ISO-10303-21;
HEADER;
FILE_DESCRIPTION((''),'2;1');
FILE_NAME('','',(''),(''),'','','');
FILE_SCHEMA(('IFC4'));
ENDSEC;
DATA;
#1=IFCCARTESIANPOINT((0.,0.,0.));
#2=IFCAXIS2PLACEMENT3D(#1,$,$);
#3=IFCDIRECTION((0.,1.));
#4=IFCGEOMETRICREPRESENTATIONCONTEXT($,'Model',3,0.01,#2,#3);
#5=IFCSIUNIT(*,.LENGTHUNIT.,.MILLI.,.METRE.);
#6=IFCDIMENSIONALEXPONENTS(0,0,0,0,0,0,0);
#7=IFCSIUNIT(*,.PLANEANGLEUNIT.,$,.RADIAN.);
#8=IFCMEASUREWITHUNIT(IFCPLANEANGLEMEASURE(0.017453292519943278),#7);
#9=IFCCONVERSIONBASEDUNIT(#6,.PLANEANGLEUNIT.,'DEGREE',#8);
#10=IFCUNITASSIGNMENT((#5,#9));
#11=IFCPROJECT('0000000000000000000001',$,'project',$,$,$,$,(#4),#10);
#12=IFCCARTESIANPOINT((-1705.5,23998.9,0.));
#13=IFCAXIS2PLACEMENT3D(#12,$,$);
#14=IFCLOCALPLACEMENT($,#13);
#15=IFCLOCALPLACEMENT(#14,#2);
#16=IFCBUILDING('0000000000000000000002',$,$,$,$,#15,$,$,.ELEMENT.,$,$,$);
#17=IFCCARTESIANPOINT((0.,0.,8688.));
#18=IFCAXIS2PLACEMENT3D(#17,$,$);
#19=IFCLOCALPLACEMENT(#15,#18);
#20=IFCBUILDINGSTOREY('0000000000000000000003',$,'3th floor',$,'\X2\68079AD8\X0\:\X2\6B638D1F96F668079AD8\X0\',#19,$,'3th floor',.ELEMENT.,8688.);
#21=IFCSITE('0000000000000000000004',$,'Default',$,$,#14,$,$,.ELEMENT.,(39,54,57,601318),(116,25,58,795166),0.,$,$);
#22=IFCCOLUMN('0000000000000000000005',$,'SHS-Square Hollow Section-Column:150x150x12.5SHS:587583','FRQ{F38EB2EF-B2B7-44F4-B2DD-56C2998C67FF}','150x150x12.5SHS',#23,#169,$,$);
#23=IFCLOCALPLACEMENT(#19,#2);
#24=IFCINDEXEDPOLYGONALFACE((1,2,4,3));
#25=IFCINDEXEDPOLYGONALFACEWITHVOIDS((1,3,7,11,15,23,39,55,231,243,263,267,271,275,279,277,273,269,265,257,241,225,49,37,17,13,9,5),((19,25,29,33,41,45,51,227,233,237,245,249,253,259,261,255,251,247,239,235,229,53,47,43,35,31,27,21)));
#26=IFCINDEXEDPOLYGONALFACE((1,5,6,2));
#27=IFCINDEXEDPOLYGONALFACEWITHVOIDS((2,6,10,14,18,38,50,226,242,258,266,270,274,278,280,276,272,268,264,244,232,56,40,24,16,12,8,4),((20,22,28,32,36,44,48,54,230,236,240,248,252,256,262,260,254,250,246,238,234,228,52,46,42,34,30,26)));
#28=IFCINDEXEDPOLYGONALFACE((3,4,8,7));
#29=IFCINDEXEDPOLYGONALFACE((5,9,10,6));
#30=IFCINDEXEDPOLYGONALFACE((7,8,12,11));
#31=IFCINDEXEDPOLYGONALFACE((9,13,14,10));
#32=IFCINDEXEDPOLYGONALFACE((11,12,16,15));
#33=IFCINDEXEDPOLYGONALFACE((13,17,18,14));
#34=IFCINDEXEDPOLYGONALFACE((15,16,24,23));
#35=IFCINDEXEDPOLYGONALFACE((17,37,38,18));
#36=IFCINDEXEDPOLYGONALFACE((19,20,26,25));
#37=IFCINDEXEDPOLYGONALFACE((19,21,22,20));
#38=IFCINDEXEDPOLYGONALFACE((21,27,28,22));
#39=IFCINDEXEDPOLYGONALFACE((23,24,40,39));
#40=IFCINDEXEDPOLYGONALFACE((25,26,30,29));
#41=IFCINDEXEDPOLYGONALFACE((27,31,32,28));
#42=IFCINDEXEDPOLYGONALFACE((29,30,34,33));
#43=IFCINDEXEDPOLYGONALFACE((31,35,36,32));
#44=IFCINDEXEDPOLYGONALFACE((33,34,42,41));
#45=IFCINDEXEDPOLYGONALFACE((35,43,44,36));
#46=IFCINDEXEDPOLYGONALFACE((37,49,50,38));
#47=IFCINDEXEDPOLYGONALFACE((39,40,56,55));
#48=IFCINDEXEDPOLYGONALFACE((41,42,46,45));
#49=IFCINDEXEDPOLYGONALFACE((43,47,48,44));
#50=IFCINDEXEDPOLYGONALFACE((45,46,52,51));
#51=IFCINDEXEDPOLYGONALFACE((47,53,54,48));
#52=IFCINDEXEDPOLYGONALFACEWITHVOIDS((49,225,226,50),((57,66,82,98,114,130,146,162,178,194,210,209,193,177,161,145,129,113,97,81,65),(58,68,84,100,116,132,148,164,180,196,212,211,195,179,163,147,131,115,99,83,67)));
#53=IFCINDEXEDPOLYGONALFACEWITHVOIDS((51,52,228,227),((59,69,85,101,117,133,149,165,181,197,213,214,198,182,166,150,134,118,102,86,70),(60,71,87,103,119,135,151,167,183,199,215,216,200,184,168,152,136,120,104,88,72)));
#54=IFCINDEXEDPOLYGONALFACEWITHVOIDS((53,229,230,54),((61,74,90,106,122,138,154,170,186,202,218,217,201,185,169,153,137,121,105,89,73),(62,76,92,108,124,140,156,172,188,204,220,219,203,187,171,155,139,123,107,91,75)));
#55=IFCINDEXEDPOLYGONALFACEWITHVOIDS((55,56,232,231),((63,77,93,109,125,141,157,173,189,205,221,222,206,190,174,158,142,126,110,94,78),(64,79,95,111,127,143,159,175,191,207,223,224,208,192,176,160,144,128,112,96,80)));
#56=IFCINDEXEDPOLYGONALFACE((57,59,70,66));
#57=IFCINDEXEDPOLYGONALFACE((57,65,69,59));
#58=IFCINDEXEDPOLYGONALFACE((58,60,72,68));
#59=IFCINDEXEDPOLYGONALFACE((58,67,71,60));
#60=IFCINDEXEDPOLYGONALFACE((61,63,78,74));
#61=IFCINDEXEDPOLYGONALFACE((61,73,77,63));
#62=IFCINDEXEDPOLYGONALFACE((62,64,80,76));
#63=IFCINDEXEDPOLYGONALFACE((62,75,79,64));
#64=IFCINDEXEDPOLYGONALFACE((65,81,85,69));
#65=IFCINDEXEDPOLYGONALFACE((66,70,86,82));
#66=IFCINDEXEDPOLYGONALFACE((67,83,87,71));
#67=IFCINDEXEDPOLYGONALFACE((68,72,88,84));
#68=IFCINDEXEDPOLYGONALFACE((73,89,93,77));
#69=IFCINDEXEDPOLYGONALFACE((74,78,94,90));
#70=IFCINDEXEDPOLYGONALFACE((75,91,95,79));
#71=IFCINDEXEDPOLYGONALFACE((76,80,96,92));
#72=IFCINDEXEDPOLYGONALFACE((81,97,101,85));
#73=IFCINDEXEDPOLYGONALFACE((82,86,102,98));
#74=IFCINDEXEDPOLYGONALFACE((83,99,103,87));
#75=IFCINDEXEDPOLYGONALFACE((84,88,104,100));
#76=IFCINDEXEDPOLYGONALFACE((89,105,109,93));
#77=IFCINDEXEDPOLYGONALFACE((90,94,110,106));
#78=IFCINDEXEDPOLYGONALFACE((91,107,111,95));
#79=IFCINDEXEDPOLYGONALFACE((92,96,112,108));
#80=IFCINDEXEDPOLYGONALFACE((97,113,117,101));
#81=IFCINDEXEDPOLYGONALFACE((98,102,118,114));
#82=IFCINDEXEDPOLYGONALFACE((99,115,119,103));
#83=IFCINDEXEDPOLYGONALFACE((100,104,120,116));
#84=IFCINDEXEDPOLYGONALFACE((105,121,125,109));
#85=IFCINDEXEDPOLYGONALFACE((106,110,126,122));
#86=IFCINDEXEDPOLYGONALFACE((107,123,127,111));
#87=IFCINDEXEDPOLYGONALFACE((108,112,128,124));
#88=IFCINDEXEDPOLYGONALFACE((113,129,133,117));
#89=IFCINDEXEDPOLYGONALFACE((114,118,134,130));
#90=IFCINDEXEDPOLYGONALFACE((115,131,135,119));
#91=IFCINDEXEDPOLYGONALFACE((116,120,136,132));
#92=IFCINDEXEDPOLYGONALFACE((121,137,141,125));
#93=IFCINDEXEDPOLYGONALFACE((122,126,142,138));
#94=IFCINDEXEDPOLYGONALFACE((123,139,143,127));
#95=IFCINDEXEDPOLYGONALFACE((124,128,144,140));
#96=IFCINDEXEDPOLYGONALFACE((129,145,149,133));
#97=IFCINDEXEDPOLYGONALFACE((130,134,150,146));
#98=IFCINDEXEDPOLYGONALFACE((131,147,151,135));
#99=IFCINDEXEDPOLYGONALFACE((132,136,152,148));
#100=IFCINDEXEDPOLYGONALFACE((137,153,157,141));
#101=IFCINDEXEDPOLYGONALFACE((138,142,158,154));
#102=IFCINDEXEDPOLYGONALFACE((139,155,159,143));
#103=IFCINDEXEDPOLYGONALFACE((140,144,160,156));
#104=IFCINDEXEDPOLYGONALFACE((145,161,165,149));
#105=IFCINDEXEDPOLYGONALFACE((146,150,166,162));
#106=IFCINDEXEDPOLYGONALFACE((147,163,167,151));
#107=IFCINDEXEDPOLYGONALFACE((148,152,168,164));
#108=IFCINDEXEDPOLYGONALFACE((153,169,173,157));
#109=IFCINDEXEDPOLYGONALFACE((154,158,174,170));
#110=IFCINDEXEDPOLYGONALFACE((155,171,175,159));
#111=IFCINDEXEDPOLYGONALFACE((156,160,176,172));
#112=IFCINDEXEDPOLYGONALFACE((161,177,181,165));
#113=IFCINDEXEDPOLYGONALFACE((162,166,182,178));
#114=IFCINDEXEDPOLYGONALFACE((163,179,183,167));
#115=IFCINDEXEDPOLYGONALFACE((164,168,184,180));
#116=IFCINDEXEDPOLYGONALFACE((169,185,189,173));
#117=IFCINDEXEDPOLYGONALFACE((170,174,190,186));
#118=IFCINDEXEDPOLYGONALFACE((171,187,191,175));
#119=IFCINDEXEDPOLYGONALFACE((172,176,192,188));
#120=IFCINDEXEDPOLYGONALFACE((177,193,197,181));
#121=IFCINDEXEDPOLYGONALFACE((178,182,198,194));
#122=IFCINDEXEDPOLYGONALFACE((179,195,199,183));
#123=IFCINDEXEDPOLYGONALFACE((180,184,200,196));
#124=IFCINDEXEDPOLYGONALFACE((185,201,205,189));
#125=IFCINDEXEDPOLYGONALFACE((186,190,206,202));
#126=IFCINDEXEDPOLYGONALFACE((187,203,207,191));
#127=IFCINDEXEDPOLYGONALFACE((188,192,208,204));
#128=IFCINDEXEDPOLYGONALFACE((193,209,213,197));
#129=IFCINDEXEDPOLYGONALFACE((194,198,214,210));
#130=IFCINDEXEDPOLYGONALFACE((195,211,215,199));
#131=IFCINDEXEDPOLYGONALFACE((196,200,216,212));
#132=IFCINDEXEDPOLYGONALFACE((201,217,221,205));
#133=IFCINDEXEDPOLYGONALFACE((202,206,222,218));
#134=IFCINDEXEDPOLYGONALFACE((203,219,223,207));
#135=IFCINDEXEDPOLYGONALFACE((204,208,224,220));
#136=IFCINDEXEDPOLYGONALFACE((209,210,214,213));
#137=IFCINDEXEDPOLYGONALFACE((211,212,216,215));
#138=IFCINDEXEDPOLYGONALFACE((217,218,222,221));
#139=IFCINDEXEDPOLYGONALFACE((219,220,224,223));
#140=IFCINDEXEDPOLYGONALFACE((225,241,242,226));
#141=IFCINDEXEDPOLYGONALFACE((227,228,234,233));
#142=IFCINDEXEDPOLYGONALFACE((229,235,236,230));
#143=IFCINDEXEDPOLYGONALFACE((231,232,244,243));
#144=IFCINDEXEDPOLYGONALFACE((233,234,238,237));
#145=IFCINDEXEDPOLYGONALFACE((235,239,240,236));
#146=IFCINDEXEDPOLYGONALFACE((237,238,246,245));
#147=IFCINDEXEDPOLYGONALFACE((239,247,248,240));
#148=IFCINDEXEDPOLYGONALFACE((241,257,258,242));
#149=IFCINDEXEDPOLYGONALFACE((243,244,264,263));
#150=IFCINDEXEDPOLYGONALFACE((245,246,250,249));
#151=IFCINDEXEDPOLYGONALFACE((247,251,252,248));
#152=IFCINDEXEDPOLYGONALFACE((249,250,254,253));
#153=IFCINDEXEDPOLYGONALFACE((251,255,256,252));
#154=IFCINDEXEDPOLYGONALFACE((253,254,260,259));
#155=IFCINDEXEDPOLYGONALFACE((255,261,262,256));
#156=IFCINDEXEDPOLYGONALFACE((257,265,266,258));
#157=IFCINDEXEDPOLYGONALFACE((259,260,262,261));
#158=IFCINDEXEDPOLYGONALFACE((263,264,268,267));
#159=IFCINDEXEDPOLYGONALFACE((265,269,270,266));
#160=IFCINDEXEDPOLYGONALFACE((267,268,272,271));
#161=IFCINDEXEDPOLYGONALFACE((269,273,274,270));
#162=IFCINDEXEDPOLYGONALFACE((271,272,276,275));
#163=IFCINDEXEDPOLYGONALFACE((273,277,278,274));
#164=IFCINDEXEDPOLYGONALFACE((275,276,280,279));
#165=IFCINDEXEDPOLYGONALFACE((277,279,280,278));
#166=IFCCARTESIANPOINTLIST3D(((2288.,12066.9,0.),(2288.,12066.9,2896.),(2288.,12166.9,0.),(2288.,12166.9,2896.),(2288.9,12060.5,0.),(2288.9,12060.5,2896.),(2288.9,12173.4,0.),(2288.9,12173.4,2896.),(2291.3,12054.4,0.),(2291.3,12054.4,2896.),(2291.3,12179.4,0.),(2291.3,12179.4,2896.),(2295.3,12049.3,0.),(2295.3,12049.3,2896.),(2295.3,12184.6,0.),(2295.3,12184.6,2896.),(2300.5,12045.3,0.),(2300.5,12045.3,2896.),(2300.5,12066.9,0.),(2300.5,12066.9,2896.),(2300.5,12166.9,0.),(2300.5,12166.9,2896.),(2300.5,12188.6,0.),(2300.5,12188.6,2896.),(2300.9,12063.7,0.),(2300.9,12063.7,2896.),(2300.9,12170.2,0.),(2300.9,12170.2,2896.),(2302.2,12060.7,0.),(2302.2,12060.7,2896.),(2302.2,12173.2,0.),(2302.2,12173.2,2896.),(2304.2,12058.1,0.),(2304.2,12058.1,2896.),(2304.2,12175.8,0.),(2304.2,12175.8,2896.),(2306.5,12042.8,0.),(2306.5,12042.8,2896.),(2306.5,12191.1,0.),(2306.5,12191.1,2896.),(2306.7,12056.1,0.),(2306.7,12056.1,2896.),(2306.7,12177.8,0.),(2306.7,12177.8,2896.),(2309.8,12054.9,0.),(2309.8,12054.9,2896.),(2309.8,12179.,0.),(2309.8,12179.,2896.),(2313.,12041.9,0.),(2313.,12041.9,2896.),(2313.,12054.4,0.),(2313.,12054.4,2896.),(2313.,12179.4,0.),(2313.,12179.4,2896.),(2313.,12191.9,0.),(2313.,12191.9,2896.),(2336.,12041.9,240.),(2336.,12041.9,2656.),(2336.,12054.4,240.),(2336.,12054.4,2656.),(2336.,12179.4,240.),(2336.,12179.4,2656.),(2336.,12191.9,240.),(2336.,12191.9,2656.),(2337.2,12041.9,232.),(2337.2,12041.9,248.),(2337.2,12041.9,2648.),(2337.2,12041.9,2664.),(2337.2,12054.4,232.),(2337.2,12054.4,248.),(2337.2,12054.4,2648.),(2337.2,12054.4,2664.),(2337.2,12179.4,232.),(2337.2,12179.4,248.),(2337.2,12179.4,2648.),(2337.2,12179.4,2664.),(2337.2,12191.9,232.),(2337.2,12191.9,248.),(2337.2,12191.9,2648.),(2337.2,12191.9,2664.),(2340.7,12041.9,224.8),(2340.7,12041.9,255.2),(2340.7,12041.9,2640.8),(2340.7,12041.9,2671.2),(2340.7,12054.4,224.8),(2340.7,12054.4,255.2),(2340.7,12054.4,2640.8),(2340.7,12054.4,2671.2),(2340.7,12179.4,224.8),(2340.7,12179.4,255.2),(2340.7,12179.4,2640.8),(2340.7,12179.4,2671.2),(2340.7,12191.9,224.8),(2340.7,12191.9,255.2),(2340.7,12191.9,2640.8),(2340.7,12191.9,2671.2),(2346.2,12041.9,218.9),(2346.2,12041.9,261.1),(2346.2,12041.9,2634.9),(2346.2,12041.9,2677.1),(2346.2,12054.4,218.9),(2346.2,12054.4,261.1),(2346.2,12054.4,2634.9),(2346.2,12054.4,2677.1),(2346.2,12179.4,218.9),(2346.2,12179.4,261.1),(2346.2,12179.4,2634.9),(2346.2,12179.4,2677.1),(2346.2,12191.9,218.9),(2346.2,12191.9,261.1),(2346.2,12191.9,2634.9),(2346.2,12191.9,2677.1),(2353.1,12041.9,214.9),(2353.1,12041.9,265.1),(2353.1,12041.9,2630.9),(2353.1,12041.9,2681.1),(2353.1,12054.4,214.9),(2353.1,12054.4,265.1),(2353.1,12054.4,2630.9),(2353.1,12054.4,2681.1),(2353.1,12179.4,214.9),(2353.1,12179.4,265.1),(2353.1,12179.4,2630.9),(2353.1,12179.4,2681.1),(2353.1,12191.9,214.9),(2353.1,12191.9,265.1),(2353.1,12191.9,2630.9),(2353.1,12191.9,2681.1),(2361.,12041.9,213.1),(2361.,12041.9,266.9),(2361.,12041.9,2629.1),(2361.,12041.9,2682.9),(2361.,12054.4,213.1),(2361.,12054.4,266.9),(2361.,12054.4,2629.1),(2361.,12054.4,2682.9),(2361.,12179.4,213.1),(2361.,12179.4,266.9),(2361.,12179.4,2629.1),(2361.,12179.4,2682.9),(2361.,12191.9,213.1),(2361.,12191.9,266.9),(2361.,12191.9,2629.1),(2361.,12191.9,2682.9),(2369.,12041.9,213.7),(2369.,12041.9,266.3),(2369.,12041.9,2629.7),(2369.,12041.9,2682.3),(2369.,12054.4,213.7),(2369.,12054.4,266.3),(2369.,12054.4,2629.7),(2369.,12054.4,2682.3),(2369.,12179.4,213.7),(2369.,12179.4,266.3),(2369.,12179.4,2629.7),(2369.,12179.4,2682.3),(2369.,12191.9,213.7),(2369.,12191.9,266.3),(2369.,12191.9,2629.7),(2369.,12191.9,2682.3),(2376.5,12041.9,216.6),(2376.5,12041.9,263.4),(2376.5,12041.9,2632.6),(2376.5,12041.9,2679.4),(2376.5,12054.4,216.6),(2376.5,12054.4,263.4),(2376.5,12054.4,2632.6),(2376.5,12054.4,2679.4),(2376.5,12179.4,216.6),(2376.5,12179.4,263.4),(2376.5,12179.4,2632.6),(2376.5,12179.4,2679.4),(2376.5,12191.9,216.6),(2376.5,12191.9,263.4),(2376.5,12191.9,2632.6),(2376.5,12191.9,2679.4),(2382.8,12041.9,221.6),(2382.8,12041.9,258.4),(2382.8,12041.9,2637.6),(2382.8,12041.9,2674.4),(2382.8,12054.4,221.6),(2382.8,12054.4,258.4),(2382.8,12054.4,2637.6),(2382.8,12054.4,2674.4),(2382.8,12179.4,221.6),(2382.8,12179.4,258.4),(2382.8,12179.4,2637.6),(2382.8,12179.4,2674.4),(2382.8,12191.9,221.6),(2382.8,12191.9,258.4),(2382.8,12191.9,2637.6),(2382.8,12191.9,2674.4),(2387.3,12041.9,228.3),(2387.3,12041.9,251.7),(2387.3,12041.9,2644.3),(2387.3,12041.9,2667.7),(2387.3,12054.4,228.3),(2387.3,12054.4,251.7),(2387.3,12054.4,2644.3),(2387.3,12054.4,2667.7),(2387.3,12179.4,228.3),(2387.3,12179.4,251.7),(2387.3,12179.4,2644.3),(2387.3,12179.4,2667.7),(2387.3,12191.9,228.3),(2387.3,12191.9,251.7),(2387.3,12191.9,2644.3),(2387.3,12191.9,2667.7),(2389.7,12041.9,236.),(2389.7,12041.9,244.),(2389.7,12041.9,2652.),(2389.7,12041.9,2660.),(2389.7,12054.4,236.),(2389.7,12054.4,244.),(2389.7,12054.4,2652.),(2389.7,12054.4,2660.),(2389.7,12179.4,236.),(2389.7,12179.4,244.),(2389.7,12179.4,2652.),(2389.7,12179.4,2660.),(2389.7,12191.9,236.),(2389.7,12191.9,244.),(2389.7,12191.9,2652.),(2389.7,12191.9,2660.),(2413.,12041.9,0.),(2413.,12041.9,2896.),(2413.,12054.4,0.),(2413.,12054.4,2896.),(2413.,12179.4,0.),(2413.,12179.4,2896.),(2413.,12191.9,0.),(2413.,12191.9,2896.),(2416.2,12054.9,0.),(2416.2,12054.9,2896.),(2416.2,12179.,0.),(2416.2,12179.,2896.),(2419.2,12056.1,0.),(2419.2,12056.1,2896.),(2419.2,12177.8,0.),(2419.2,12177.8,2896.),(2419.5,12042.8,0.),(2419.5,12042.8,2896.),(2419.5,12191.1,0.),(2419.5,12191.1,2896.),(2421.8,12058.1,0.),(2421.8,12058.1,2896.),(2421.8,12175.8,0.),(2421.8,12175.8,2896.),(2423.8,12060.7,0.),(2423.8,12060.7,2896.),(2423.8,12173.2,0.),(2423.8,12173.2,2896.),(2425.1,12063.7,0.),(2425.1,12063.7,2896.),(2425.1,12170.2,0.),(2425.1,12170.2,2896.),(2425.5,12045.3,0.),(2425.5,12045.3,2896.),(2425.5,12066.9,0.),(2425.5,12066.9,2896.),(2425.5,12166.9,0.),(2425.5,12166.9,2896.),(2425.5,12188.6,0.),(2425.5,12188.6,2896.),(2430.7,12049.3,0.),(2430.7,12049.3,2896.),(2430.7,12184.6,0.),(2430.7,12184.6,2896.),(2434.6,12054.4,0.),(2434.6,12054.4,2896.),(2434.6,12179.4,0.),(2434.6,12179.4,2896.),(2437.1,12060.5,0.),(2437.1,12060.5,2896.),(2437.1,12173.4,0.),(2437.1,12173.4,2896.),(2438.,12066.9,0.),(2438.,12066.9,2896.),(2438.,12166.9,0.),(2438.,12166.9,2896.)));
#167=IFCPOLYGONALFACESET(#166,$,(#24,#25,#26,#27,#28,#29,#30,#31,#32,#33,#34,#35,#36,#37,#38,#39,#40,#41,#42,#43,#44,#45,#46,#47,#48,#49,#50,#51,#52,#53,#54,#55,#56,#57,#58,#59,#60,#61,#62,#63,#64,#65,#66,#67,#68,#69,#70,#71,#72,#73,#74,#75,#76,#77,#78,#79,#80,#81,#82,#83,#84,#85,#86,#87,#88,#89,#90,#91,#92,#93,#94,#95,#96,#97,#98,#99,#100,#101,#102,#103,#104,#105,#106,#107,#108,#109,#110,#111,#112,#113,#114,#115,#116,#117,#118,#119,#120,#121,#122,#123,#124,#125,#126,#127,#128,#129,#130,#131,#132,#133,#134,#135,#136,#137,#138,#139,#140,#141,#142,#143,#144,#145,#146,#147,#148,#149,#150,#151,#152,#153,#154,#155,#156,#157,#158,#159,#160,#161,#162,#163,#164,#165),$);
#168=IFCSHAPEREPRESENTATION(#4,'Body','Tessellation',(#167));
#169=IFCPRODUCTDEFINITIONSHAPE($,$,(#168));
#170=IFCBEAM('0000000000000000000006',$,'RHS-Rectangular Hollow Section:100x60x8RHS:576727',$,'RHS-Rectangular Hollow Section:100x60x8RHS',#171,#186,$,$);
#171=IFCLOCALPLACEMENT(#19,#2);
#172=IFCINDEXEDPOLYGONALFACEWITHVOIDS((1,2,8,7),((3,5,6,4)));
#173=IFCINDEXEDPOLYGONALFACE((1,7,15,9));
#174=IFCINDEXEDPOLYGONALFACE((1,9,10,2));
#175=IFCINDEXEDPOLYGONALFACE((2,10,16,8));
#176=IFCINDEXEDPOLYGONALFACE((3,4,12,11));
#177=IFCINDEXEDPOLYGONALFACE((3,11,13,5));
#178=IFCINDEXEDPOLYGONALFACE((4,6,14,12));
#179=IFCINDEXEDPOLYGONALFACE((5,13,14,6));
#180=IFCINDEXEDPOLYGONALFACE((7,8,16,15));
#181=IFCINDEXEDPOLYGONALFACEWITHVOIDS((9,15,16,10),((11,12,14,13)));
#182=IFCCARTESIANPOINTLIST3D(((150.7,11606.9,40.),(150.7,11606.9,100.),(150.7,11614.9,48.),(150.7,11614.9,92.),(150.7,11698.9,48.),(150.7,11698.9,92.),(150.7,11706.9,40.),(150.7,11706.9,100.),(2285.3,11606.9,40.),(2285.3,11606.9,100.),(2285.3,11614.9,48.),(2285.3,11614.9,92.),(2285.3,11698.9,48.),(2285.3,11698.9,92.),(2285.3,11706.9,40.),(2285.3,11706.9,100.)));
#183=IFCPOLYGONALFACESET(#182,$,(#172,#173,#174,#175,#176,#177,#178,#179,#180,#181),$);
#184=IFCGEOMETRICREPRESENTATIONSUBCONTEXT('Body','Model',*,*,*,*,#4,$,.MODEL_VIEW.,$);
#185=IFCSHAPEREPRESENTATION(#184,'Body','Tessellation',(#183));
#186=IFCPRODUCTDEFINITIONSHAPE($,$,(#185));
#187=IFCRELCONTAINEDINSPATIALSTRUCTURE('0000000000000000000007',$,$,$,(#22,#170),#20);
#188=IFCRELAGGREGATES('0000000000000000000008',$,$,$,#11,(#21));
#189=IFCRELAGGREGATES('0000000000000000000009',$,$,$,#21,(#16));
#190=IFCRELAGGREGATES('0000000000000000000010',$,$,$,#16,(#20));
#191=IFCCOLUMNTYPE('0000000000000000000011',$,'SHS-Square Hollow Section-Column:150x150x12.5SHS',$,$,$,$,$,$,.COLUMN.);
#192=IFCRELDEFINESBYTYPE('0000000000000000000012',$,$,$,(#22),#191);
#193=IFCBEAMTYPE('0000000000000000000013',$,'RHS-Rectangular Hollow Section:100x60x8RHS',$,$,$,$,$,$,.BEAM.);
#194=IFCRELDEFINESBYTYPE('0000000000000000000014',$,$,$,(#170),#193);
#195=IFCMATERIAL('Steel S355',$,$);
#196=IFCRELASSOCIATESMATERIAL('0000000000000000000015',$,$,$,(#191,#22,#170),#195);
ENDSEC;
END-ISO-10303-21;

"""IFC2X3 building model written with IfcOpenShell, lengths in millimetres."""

from ifc_helpers import new_model, entity, si_unit, converted_unit, direction, frame, frame_2d, origin, origin_2d, place, context, subcontext, project, spatial, circle_curve, rectangle, hollow_rectangle, outline, extrude, boolean, material, type_object, element, save


model = new_model("IFC2X3")

# Units and contexts
model_context = context("Model", 3, precision=0.01, world=origin(), true_north=direction((0.0, 1.0)))
body_context = subcontext(model_context, "Body", "Model", "MODEL_VIEW")
ifc_project = project(units=[si_unit("LENGTHUNIT", "METRE", prefix="MILLI"), converted_unit("PLANEANGLEUNIT", "DEGREE", entity("IfcPlaneAngleMeasure", 0.017453292519943278), si_unit("PLANEANGLEUNIT", "RADIAN"), dimensions=[0, 0, 0, 0, 0, 0, 0])], contexts=[model_context])

# Site, building, storey
site_placement = place(None, frame((-1705.5, 23998.9, 0.0)))
site = spatial("IfcSite", under=ifc_project, at=site_placement, Name="Default", CompositionType="ELEMENT", RefLatitude=(39, 54, 57, 601318), RefLongitude=(116, 25, 58, 795166), RefElevation=0.0)
building_placement = place(site_placement, origin())
building = spatial("IfcBuilding", under=site, at=building_placement, CompositionType="ELEMENT")
storey_placement = place(building_placement, frame((0.0, 0.0, 8688.0)))
storey = spatial("IfcBuildingStorey", under=building, at=storey_placement, Name="3th floor", ObjectType="标高:正负零标高", LongName="3th floor", CompositionType="ELEMENT", Elevation=8688.0)

# Shared definitions
ifc_material_1 = material(Name="Steel S355")

# Column, openings
column_type_1 = type_object("IfcColumnType", Name="SHS-Square Hollow Section-Column:150x150x12.5SHS", PredefinedType="COLUMN", material=ifc_material_1)
column_1_placement = place(storey_placement, frame((2363.0, 12116.9, 2896.0), z_axis=(0.0, 0.0, 1.0), x_axis=(0.0, -1.0, 0.0)))
column_1 = element("IfcColumn", 1, at=column_1_placement, inside=storey, type_object=column_type_1, material=ifc_material_1, Name="SHS-Square Hollow Section-Column:150x150x12.5SHS:587583", Description="FRQ{F38EB2EF-B2B7-44F4-B2DD-56C2998C67FF}", ObjectType="150x150x12.5SHS", context=model_context, shape_type="SweptSolid", body=[
    extrude(hollow_rectangle(XDim=150.0, YDim=150.0, WallThickness=12.5, InnerFilletRadius=12.5, OuterFilletRadius=25.0, at=origin_2d()), origin(), (0.0, 0.0, -1.0), 2896.0),
])
opening_1_placement = place(column_1_placement, frame((175.1, 0.0, -2896.0), z_axis=(-1.0, 0.0, 0.0), x_axis=(0.0, -1.0, 0.0)))
element("IfcOpeningElement", 2, at=opening_1_placement, cuts=column_1, ObjectType="Opening", context=model_context, shape_type="SweptSolid", body=[
    extrude(outline(circle_curve(frame_2d((0.0, 240.0), x_axis=(1.0, 0.0)), 27.0)), origin(), (0.0, 0.0, 1.0), 350.2),
])
opening_2_placement = place(column_1_placement, frame((175.1, 0.0, 0.0), z_axis=(-1.0, 0.0, 0.0), x_axis=(0.0, -1.0, 0.0)))
element("IfcOpeningElement", 3, at=opening_2_placement, cuts=column_1, ObjectType="Opening", context=model_context, shape_type="SweptSolid", body=[
    extrude(outline(circle_curve(frame_2d((0.0, -240.0), x_axis=(1.0, 0.0)), 27.0)), origin(), (0.0, 0.0, 1.0), 350.2),
])

# Beam
beam_type_1 = type_object("IfcBeamType", Name="RHS-Rectangular Hollow Section:100x60x8RHS", PredefinedType="BEAM")
beam_1_placement = place(storey_placement, frame((150.7, 11706.9, 70.0)))
element("IfcBeam", 4, at=beam_1_placement, inside=storey, type_object=beam_type_1, material=ifc_material_1, Name="RHS-Rectangular Hollow Section:100x60x8RHS:576727", ObjectType="RHS-Rectangular Hollow Section:100x60x8RHS", context=body_context, shape_type="SweptSolid", body=[
    boolean("DIFFERENCE", extrude(rectangle(XDim=60.0, YDim=100.0, at=frame_2d((0.0, 0.0), x_axis=(1.0, 0.0))), frame((0.0, -50.0, 0.0), z_axis=(1.0, 0.0, 0.0), x_axis=(0.0, 0.0, -1.0)), (0.0, 0.0, 1.0), 2134.6), extrude(rectangle(XDim=44.0, YDim=84.0, at=frame_2d((0.0, 0.0), x_axis=(0.0, 1.0))), frame((2134.6, -50.0, 0.0), z_axis=(-1.0, 0.0, 0.0), x_axis=(0.0, 1.0, 0.0)), (0.0, 0.0, 1.0), 2134.6)),
])

save(model, "model.ifc")
